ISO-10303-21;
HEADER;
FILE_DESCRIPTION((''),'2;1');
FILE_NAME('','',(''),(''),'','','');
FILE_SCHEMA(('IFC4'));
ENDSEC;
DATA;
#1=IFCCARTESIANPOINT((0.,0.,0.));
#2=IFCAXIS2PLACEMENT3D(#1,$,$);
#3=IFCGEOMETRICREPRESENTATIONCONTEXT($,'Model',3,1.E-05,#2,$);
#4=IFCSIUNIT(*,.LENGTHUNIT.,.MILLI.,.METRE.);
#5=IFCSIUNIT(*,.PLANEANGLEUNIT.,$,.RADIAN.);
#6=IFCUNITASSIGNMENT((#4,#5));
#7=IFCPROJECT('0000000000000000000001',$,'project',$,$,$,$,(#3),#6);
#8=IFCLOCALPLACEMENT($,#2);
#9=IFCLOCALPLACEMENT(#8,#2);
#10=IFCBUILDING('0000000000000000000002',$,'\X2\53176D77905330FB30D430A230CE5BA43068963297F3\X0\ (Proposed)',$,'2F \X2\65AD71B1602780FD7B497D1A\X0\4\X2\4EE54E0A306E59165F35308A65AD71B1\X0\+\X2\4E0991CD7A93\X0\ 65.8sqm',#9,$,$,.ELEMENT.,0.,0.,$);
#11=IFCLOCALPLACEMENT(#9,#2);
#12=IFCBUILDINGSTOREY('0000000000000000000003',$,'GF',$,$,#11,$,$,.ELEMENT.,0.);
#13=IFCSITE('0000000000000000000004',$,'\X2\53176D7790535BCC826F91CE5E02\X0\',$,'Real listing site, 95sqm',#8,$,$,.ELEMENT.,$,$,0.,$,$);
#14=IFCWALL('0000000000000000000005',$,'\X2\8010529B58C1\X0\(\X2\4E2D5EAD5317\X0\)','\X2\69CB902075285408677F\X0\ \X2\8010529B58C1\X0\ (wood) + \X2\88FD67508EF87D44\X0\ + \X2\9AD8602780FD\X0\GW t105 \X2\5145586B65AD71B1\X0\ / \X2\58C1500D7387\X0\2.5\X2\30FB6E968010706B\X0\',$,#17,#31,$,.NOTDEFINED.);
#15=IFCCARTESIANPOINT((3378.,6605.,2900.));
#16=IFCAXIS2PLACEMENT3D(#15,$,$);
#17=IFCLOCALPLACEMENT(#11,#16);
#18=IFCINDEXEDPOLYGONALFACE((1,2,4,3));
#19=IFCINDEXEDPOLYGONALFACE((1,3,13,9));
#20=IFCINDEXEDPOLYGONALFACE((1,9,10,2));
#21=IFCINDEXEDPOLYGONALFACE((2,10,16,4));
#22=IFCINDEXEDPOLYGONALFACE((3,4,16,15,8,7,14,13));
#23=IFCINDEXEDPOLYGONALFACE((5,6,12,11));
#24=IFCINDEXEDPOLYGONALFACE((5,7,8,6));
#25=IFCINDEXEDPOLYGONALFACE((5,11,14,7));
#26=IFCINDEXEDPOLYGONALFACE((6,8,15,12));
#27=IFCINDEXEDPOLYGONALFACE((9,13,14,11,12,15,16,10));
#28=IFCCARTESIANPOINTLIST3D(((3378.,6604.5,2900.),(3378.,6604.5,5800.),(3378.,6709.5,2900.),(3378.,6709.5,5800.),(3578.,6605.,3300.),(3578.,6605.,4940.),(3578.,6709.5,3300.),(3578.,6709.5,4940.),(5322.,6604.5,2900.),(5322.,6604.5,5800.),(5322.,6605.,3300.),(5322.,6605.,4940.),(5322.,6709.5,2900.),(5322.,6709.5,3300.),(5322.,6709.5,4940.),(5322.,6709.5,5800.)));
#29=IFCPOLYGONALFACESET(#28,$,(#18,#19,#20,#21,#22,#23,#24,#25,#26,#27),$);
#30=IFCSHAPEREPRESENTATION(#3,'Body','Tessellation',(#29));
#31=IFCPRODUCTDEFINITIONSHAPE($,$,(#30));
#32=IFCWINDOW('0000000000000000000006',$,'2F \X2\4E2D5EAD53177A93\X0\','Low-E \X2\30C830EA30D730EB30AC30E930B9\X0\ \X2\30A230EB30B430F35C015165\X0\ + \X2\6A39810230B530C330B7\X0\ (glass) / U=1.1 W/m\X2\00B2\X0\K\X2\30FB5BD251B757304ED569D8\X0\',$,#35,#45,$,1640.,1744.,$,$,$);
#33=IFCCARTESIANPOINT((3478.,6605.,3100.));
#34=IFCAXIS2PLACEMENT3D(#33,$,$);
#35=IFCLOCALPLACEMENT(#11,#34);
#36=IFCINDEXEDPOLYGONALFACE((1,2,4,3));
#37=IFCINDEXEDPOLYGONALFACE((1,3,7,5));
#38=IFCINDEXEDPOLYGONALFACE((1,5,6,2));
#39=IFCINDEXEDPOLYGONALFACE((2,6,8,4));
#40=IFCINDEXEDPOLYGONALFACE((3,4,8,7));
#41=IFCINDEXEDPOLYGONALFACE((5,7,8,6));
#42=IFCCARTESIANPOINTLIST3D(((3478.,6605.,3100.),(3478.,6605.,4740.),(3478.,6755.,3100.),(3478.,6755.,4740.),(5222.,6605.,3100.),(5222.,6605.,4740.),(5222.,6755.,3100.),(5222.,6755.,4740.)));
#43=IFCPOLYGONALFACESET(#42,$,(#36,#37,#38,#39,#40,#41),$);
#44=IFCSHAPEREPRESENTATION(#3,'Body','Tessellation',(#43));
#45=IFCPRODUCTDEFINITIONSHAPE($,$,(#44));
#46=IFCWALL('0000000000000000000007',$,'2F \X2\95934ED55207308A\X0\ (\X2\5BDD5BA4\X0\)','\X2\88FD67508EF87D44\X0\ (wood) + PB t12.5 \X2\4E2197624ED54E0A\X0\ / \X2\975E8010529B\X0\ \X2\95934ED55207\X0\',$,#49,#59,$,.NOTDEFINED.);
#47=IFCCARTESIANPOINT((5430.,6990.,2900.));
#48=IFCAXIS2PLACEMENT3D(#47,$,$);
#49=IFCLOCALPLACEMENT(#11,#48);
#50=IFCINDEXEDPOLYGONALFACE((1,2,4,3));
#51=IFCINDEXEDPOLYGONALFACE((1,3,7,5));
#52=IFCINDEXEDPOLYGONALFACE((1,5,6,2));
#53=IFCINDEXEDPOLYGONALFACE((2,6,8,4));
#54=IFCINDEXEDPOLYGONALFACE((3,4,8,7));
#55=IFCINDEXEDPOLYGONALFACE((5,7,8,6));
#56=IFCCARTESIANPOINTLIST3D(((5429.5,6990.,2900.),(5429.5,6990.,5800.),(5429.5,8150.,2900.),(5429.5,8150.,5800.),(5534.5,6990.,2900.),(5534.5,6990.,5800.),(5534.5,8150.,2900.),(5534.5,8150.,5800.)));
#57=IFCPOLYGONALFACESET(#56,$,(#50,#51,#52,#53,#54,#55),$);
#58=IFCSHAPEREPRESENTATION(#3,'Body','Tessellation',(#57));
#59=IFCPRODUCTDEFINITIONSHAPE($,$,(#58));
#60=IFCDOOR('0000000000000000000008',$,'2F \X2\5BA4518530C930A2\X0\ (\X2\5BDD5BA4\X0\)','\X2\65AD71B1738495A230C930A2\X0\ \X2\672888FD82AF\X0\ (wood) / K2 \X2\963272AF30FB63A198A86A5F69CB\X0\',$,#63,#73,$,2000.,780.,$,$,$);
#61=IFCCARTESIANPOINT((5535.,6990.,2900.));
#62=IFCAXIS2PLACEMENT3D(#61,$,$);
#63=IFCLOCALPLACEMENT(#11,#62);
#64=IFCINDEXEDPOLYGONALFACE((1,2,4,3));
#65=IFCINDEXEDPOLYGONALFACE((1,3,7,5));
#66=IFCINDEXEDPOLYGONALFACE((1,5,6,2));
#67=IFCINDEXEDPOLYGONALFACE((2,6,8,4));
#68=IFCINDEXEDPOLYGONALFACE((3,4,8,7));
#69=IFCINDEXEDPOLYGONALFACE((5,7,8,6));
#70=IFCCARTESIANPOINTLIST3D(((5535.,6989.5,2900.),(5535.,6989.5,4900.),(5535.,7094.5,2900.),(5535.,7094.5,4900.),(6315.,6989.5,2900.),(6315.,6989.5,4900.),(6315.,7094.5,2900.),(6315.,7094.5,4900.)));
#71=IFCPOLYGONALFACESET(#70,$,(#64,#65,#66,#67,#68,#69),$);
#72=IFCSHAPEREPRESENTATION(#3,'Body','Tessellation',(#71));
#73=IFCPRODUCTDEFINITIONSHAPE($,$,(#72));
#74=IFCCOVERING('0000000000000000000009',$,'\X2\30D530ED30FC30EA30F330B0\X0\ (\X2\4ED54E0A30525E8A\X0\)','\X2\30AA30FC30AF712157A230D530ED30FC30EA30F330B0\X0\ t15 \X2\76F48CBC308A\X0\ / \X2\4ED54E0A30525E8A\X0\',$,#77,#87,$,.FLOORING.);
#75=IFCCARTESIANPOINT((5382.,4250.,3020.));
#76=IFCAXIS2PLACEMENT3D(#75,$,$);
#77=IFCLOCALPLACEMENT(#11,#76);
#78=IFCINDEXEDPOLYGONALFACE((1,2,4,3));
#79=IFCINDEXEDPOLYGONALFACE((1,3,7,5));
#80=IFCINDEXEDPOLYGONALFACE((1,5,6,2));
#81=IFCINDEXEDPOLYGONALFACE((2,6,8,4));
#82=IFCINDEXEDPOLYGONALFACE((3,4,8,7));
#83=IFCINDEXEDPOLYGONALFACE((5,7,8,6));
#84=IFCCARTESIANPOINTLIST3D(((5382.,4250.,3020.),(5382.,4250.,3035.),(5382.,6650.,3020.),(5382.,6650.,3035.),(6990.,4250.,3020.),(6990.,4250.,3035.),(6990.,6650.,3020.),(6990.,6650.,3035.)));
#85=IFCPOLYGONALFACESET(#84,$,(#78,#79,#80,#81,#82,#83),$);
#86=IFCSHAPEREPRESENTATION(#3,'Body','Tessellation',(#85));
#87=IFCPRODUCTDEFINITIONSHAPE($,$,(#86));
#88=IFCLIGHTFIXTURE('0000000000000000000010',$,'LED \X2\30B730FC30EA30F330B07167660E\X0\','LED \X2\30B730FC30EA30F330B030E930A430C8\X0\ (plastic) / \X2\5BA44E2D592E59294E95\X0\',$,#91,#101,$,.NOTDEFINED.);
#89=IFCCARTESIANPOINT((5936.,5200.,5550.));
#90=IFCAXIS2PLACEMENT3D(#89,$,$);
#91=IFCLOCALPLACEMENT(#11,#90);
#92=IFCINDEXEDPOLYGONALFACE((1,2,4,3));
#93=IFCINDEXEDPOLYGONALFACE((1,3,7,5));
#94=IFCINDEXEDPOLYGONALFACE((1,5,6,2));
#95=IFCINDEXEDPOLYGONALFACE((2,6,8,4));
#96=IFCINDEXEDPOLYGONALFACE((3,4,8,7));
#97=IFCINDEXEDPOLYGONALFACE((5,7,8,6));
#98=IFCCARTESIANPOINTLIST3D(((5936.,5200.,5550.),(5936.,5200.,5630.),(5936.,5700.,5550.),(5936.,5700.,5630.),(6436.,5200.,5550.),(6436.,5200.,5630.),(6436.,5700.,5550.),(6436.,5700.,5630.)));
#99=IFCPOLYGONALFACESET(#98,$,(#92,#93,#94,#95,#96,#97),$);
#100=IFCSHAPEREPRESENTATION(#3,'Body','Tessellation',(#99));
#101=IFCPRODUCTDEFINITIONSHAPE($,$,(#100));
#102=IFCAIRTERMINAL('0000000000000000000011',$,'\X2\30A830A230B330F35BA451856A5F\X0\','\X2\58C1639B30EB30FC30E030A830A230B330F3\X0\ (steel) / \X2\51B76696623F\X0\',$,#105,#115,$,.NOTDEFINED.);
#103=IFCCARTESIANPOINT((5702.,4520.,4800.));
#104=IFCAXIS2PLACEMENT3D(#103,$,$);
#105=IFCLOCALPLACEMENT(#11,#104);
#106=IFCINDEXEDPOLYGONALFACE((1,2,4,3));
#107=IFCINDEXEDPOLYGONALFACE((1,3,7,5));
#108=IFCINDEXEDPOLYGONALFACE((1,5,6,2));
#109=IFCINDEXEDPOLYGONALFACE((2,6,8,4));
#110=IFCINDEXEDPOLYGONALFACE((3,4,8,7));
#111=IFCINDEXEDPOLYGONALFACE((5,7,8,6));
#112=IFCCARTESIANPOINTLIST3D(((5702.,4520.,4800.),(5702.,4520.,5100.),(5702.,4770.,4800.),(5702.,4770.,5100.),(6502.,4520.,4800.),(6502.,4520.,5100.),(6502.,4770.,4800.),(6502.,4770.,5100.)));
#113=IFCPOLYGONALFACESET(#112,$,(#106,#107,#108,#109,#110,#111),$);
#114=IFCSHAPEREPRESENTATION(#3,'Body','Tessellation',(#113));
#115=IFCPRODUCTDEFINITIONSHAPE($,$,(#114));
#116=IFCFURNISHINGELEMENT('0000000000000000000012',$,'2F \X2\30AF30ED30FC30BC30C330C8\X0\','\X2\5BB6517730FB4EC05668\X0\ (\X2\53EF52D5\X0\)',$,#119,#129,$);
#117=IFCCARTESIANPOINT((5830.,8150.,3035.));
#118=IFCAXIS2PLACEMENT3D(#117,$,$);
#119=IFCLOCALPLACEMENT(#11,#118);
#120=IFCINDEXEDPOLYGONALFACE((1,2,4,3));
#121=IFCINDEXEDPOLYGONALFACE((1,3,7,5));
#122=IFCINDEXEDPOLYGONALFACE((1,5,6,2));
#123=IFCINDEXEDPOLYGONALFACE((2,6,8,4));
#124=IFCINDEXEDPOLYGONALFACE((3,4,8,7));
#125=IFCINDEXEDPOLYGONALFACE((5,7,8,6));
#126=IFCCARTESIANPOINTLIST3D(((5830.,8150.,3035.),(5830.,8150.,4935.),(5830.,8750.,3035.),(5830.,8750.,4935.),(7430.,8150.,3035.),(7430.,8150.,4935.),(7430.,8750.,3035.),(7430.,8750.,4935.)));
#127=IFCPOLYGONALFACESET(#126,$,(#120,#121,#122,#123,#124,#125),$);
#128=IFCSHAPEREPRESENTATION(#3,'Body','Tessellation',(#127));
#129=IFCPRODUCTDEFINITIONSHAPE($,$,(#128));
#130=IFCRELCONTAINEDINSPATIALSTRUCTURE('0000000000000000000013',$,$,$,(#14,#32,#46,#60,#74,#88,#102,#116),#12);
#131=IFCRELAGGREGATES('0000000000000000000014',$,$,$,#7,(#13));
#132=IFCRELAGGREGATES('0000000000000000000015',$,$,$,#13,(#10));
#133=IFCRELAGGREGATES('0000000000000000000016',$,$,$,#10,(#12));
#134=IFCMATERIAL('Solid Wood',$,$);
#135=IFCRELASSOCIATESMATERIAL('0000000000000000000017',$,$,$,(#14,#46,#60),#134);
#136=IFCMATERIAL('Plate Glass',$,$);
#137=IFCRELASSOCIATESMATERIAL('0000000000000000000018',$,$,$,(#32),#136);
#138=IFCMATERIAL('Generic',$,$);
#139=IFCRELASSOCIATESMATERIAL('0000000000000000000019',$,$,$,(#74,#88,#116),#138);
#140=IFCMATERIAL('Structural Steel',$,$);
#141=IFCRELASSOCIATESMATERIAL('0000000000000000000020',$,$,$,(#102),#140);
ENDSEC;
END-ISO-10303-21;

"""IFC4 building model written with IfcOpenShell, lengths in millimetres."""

from ifc_helpers import new_model, si_unit, frame, frame_2d, origin, place, context, project, spatial, rectangle, extrude, material, element, fill, save


model = new_model("IFC4")

# Units and contexts
model_context = context("Model", 3, precision=1e-05, world=origin())
ifc_project = project(units=[si_unit("LENGTHUNIT", "METRE", prefix="MILLI"), si_unit("PLANEANGLEUNIT", "RADIAN")], contexts=[model_context])

# Site, building, storey
site_placement = place(None, origin())
site = spatial("IfcSite", under=ifc_project, at=site_placement, Name="北海道富良野市", ObjectType="Real listing site, 95sqm", CompositionType="ELEMENT", RefElevation=0.0)
building_placement = place(site_placement, origin())
building = spatial("IfcBuilding", under=site, at=building_placement, Name="北海道・ピアノ室と防音 (Proposed)", ObjectType="2F 断熱性能等級4以上の外張り断熱+三重窓 65.8sqm", CompositionType="ELEMENT", ElevationOfRefHeight=0.0, ElevationOfTerrain=0.0)
storey_placement = place(building_placement, origin())
storey = spatial("IfcBuildingStorey", under=building, at=storey_placement, Name="GF", CompositionType="ELEMENT", Elevation=0.0)

# Shared definitions
ifc_material_1 = material(Name="Solid Wood")

# Wall, opening, window
wall_1_placement = place(storey_placement, frame((3378.0, 6605.0, 2900.0)))
wall_1 = element("IfcWall", 1, at=wall_1_placement, inside=storey, material=ifc_material_1, Name="耐力壁(中庭北)", Description="構造用合板 耐力壁 (wood) + 製材軸組 + 高性能GW t105 充填断熱 / 壁倍率2.5・準耐火", PredefinedType="NOTDEFINED", context=model_context, shape_type="SweptSolid", body=[
    extrude(rectangle(XDim=1944.0, YDim=105.0, at=frame_2d((972.0, 52.0))), frame((3378.0, 6605.0, 2900.0)), (0.0, 0.0, 1.0), 2900.0),
])
opening_placement = place(storey_placement, frame((3478.0, 6605.0, 3100.0)))
opening = element("IfcOpeningElement", 2, at=opening_placement, cuts=wall_1, PredefinedType="NOTDEFINED", context=model_context, shape_type="SweptSolid", body=[
    extrude(rectangle(XDim=1744.0, YDim=150.0, at=frame_2d((872.0, 75.0))), frame((3478.0, 6605.0, 3100.0)), (0.0, 0.0, 1.0), 1640.0),
])
ifc_material_2 = material(Name="Plate Glass")
window_placement = place(storey_placement, frame((3478.0, 6605.0, 3100.0)))
window = element("IfcWindow", 3, at=window_placement, inside=storey, material=ifc_material_2, Name="2F 中庭北窓", Description="Low-E トリプルガラス アルゴン封入 + 樹脂サッシ (glass) / U=1.1 W/m²K・寒冷地仕様", OverallHeight=1640.0, OverallWidth=1744.0, context=model_context, shape_type="SweptSolid", body=[
    extrude(rectangle(XDim=1744.0, YDim=150.0, at=frame_2d((872.0, 75.0))), frame((3478.0, 6605.0, 3100.0)), (0.0, 0.0, 1.0), 1640.0),
])
fill(opening, window)

# Wall
wall_2_placement = place(storey_placement, frame((5430.0, 6990.0, 2900.0)))
element("IfcWall", 4, at=wall_2_placement, inside=storey, material=ifc_material_1, Name="2F 間仕切り (寝室)", Description="製材軸組 (wood) + PB t12.5 両面仕上 / 非耐力 間仕切", PredefinedType="NOTDEFINED", context=model_context, shape_type="SweptSolid", body=[
    extrude(rectangle(XDim=105.0, YDim=1160.0, at=frame_2d((52.0, 580.0))), frame((5430.0, 6990.0, 2900.0)), (0.0, 0.0, 1.0), 2900.0),
])

# Door
door_placement = place(storey_placement, frame((5535.0, 6990.0, 2900.0)))
element("IfcDoor", 5, at=door_placement, inside=storey, material=ifc_material_1, Name="2F 室内ドア (寝室)", Description="断熱玄関ドア 木製芯 (wood) / K2 防犯・採風機構", OverallHeight=2000.0, OverallWidth=780.0, context=model_context, shape_type="SweptSolid", body=[
    extrude(rectangle(XDim=780.0, YDim=105.0, at=frame_2d((390.0, 52.0))), frame((5535.0, 6990.0, 2900.0)), (0.0, 0.0, 1.0), 2000.0),
])

# Covering
ifc_material_3 = material(Name="Generic")
covering_placement = place(storey_placement, frame((5382.0, 4250.0, 3020.0)))
element("IfcCovering", 6, at=covering_placement, inside=storey, material=ifc_material_3, Name="フローリング (仕上げ床)", Description="オーク無垢フローリング t15 直貼り / 仕上げ床", PredefinedType="FLOORING", context=model_context, shape_type="SweptSolid", body=[
    extrude(rectangle(XDim=1608.0, YDim=2400.0, at=frame_2d((804.0, 1200.0))), frame((5382.0, 4250.0, 3020.0)), (0.0, 0.0, 1.0), 15.0),
])

# Light fixture
light_fixture_placement = place(storey_placement, frame((5936.0, 5200.0, 5550.0)))
element("IfcLightFixture", 7, at=light_fixture_placement, inside=storey, material=ifc_material_3, Name="LED シーリング照明", Description="LED シーリングライト (plastic) / 室中央天井", PredefinedType="NOTDEFINED", context=model_context, shape_type="SweptSolid", body=[
    extrude(rectangle(XDim=500.0, YDim=500.0, at=frame_2d((250.0, 250.0))), frame((5936.0, 5200.0, 5550.0)), (0.0, 0.0, 1.0), 80.0),
])

# Air terminal
ifc_material_4 = material(Name="Structural Steel")
air_terminal_placement = place(storey_placement, frame((5702.0, 4520.0, 4800.0)))
element("IfcAirTerminal", 8, at=air_terminal_placement, inside=storey, material=ifc_material_4, Name="エアコン室内機", Description="壁掛ルームエアコン (steel) / 冷暖房", PredefinedType="NOTDEFINED", context=model_context, shape_type="SweptSolid", body=[
    extrude(rectangle(XDim=800.0, YDim=250.0, at=frame_2d((400.0, 125.0))), frame((5702.0, 4520.0, 4800.0)), (0.0, 0.0, 1.0), 300.0),
])

# Furnishing element
furnishing_placement = place(storey_placement, frame((5830.0, 8150.0, 3035.0)))
element("IfcFurnishingElement", 9, at=furnishing_placement, inside=storey, material=ifc_material_3, Name="2F クローゼット", Description="家具・什器 (可動)", context=model_context, shape_type="SweptSolid", body=[
    extrude(rectangle(XDim=1600.0, YDim=600.0, at=frame_2d((800.0, 300.0))), frame((5830.0, 8150.0, 3035.0)), (0.0, 0.0, 1.0), 1900.0),
])

save(model, "model.ifc")
